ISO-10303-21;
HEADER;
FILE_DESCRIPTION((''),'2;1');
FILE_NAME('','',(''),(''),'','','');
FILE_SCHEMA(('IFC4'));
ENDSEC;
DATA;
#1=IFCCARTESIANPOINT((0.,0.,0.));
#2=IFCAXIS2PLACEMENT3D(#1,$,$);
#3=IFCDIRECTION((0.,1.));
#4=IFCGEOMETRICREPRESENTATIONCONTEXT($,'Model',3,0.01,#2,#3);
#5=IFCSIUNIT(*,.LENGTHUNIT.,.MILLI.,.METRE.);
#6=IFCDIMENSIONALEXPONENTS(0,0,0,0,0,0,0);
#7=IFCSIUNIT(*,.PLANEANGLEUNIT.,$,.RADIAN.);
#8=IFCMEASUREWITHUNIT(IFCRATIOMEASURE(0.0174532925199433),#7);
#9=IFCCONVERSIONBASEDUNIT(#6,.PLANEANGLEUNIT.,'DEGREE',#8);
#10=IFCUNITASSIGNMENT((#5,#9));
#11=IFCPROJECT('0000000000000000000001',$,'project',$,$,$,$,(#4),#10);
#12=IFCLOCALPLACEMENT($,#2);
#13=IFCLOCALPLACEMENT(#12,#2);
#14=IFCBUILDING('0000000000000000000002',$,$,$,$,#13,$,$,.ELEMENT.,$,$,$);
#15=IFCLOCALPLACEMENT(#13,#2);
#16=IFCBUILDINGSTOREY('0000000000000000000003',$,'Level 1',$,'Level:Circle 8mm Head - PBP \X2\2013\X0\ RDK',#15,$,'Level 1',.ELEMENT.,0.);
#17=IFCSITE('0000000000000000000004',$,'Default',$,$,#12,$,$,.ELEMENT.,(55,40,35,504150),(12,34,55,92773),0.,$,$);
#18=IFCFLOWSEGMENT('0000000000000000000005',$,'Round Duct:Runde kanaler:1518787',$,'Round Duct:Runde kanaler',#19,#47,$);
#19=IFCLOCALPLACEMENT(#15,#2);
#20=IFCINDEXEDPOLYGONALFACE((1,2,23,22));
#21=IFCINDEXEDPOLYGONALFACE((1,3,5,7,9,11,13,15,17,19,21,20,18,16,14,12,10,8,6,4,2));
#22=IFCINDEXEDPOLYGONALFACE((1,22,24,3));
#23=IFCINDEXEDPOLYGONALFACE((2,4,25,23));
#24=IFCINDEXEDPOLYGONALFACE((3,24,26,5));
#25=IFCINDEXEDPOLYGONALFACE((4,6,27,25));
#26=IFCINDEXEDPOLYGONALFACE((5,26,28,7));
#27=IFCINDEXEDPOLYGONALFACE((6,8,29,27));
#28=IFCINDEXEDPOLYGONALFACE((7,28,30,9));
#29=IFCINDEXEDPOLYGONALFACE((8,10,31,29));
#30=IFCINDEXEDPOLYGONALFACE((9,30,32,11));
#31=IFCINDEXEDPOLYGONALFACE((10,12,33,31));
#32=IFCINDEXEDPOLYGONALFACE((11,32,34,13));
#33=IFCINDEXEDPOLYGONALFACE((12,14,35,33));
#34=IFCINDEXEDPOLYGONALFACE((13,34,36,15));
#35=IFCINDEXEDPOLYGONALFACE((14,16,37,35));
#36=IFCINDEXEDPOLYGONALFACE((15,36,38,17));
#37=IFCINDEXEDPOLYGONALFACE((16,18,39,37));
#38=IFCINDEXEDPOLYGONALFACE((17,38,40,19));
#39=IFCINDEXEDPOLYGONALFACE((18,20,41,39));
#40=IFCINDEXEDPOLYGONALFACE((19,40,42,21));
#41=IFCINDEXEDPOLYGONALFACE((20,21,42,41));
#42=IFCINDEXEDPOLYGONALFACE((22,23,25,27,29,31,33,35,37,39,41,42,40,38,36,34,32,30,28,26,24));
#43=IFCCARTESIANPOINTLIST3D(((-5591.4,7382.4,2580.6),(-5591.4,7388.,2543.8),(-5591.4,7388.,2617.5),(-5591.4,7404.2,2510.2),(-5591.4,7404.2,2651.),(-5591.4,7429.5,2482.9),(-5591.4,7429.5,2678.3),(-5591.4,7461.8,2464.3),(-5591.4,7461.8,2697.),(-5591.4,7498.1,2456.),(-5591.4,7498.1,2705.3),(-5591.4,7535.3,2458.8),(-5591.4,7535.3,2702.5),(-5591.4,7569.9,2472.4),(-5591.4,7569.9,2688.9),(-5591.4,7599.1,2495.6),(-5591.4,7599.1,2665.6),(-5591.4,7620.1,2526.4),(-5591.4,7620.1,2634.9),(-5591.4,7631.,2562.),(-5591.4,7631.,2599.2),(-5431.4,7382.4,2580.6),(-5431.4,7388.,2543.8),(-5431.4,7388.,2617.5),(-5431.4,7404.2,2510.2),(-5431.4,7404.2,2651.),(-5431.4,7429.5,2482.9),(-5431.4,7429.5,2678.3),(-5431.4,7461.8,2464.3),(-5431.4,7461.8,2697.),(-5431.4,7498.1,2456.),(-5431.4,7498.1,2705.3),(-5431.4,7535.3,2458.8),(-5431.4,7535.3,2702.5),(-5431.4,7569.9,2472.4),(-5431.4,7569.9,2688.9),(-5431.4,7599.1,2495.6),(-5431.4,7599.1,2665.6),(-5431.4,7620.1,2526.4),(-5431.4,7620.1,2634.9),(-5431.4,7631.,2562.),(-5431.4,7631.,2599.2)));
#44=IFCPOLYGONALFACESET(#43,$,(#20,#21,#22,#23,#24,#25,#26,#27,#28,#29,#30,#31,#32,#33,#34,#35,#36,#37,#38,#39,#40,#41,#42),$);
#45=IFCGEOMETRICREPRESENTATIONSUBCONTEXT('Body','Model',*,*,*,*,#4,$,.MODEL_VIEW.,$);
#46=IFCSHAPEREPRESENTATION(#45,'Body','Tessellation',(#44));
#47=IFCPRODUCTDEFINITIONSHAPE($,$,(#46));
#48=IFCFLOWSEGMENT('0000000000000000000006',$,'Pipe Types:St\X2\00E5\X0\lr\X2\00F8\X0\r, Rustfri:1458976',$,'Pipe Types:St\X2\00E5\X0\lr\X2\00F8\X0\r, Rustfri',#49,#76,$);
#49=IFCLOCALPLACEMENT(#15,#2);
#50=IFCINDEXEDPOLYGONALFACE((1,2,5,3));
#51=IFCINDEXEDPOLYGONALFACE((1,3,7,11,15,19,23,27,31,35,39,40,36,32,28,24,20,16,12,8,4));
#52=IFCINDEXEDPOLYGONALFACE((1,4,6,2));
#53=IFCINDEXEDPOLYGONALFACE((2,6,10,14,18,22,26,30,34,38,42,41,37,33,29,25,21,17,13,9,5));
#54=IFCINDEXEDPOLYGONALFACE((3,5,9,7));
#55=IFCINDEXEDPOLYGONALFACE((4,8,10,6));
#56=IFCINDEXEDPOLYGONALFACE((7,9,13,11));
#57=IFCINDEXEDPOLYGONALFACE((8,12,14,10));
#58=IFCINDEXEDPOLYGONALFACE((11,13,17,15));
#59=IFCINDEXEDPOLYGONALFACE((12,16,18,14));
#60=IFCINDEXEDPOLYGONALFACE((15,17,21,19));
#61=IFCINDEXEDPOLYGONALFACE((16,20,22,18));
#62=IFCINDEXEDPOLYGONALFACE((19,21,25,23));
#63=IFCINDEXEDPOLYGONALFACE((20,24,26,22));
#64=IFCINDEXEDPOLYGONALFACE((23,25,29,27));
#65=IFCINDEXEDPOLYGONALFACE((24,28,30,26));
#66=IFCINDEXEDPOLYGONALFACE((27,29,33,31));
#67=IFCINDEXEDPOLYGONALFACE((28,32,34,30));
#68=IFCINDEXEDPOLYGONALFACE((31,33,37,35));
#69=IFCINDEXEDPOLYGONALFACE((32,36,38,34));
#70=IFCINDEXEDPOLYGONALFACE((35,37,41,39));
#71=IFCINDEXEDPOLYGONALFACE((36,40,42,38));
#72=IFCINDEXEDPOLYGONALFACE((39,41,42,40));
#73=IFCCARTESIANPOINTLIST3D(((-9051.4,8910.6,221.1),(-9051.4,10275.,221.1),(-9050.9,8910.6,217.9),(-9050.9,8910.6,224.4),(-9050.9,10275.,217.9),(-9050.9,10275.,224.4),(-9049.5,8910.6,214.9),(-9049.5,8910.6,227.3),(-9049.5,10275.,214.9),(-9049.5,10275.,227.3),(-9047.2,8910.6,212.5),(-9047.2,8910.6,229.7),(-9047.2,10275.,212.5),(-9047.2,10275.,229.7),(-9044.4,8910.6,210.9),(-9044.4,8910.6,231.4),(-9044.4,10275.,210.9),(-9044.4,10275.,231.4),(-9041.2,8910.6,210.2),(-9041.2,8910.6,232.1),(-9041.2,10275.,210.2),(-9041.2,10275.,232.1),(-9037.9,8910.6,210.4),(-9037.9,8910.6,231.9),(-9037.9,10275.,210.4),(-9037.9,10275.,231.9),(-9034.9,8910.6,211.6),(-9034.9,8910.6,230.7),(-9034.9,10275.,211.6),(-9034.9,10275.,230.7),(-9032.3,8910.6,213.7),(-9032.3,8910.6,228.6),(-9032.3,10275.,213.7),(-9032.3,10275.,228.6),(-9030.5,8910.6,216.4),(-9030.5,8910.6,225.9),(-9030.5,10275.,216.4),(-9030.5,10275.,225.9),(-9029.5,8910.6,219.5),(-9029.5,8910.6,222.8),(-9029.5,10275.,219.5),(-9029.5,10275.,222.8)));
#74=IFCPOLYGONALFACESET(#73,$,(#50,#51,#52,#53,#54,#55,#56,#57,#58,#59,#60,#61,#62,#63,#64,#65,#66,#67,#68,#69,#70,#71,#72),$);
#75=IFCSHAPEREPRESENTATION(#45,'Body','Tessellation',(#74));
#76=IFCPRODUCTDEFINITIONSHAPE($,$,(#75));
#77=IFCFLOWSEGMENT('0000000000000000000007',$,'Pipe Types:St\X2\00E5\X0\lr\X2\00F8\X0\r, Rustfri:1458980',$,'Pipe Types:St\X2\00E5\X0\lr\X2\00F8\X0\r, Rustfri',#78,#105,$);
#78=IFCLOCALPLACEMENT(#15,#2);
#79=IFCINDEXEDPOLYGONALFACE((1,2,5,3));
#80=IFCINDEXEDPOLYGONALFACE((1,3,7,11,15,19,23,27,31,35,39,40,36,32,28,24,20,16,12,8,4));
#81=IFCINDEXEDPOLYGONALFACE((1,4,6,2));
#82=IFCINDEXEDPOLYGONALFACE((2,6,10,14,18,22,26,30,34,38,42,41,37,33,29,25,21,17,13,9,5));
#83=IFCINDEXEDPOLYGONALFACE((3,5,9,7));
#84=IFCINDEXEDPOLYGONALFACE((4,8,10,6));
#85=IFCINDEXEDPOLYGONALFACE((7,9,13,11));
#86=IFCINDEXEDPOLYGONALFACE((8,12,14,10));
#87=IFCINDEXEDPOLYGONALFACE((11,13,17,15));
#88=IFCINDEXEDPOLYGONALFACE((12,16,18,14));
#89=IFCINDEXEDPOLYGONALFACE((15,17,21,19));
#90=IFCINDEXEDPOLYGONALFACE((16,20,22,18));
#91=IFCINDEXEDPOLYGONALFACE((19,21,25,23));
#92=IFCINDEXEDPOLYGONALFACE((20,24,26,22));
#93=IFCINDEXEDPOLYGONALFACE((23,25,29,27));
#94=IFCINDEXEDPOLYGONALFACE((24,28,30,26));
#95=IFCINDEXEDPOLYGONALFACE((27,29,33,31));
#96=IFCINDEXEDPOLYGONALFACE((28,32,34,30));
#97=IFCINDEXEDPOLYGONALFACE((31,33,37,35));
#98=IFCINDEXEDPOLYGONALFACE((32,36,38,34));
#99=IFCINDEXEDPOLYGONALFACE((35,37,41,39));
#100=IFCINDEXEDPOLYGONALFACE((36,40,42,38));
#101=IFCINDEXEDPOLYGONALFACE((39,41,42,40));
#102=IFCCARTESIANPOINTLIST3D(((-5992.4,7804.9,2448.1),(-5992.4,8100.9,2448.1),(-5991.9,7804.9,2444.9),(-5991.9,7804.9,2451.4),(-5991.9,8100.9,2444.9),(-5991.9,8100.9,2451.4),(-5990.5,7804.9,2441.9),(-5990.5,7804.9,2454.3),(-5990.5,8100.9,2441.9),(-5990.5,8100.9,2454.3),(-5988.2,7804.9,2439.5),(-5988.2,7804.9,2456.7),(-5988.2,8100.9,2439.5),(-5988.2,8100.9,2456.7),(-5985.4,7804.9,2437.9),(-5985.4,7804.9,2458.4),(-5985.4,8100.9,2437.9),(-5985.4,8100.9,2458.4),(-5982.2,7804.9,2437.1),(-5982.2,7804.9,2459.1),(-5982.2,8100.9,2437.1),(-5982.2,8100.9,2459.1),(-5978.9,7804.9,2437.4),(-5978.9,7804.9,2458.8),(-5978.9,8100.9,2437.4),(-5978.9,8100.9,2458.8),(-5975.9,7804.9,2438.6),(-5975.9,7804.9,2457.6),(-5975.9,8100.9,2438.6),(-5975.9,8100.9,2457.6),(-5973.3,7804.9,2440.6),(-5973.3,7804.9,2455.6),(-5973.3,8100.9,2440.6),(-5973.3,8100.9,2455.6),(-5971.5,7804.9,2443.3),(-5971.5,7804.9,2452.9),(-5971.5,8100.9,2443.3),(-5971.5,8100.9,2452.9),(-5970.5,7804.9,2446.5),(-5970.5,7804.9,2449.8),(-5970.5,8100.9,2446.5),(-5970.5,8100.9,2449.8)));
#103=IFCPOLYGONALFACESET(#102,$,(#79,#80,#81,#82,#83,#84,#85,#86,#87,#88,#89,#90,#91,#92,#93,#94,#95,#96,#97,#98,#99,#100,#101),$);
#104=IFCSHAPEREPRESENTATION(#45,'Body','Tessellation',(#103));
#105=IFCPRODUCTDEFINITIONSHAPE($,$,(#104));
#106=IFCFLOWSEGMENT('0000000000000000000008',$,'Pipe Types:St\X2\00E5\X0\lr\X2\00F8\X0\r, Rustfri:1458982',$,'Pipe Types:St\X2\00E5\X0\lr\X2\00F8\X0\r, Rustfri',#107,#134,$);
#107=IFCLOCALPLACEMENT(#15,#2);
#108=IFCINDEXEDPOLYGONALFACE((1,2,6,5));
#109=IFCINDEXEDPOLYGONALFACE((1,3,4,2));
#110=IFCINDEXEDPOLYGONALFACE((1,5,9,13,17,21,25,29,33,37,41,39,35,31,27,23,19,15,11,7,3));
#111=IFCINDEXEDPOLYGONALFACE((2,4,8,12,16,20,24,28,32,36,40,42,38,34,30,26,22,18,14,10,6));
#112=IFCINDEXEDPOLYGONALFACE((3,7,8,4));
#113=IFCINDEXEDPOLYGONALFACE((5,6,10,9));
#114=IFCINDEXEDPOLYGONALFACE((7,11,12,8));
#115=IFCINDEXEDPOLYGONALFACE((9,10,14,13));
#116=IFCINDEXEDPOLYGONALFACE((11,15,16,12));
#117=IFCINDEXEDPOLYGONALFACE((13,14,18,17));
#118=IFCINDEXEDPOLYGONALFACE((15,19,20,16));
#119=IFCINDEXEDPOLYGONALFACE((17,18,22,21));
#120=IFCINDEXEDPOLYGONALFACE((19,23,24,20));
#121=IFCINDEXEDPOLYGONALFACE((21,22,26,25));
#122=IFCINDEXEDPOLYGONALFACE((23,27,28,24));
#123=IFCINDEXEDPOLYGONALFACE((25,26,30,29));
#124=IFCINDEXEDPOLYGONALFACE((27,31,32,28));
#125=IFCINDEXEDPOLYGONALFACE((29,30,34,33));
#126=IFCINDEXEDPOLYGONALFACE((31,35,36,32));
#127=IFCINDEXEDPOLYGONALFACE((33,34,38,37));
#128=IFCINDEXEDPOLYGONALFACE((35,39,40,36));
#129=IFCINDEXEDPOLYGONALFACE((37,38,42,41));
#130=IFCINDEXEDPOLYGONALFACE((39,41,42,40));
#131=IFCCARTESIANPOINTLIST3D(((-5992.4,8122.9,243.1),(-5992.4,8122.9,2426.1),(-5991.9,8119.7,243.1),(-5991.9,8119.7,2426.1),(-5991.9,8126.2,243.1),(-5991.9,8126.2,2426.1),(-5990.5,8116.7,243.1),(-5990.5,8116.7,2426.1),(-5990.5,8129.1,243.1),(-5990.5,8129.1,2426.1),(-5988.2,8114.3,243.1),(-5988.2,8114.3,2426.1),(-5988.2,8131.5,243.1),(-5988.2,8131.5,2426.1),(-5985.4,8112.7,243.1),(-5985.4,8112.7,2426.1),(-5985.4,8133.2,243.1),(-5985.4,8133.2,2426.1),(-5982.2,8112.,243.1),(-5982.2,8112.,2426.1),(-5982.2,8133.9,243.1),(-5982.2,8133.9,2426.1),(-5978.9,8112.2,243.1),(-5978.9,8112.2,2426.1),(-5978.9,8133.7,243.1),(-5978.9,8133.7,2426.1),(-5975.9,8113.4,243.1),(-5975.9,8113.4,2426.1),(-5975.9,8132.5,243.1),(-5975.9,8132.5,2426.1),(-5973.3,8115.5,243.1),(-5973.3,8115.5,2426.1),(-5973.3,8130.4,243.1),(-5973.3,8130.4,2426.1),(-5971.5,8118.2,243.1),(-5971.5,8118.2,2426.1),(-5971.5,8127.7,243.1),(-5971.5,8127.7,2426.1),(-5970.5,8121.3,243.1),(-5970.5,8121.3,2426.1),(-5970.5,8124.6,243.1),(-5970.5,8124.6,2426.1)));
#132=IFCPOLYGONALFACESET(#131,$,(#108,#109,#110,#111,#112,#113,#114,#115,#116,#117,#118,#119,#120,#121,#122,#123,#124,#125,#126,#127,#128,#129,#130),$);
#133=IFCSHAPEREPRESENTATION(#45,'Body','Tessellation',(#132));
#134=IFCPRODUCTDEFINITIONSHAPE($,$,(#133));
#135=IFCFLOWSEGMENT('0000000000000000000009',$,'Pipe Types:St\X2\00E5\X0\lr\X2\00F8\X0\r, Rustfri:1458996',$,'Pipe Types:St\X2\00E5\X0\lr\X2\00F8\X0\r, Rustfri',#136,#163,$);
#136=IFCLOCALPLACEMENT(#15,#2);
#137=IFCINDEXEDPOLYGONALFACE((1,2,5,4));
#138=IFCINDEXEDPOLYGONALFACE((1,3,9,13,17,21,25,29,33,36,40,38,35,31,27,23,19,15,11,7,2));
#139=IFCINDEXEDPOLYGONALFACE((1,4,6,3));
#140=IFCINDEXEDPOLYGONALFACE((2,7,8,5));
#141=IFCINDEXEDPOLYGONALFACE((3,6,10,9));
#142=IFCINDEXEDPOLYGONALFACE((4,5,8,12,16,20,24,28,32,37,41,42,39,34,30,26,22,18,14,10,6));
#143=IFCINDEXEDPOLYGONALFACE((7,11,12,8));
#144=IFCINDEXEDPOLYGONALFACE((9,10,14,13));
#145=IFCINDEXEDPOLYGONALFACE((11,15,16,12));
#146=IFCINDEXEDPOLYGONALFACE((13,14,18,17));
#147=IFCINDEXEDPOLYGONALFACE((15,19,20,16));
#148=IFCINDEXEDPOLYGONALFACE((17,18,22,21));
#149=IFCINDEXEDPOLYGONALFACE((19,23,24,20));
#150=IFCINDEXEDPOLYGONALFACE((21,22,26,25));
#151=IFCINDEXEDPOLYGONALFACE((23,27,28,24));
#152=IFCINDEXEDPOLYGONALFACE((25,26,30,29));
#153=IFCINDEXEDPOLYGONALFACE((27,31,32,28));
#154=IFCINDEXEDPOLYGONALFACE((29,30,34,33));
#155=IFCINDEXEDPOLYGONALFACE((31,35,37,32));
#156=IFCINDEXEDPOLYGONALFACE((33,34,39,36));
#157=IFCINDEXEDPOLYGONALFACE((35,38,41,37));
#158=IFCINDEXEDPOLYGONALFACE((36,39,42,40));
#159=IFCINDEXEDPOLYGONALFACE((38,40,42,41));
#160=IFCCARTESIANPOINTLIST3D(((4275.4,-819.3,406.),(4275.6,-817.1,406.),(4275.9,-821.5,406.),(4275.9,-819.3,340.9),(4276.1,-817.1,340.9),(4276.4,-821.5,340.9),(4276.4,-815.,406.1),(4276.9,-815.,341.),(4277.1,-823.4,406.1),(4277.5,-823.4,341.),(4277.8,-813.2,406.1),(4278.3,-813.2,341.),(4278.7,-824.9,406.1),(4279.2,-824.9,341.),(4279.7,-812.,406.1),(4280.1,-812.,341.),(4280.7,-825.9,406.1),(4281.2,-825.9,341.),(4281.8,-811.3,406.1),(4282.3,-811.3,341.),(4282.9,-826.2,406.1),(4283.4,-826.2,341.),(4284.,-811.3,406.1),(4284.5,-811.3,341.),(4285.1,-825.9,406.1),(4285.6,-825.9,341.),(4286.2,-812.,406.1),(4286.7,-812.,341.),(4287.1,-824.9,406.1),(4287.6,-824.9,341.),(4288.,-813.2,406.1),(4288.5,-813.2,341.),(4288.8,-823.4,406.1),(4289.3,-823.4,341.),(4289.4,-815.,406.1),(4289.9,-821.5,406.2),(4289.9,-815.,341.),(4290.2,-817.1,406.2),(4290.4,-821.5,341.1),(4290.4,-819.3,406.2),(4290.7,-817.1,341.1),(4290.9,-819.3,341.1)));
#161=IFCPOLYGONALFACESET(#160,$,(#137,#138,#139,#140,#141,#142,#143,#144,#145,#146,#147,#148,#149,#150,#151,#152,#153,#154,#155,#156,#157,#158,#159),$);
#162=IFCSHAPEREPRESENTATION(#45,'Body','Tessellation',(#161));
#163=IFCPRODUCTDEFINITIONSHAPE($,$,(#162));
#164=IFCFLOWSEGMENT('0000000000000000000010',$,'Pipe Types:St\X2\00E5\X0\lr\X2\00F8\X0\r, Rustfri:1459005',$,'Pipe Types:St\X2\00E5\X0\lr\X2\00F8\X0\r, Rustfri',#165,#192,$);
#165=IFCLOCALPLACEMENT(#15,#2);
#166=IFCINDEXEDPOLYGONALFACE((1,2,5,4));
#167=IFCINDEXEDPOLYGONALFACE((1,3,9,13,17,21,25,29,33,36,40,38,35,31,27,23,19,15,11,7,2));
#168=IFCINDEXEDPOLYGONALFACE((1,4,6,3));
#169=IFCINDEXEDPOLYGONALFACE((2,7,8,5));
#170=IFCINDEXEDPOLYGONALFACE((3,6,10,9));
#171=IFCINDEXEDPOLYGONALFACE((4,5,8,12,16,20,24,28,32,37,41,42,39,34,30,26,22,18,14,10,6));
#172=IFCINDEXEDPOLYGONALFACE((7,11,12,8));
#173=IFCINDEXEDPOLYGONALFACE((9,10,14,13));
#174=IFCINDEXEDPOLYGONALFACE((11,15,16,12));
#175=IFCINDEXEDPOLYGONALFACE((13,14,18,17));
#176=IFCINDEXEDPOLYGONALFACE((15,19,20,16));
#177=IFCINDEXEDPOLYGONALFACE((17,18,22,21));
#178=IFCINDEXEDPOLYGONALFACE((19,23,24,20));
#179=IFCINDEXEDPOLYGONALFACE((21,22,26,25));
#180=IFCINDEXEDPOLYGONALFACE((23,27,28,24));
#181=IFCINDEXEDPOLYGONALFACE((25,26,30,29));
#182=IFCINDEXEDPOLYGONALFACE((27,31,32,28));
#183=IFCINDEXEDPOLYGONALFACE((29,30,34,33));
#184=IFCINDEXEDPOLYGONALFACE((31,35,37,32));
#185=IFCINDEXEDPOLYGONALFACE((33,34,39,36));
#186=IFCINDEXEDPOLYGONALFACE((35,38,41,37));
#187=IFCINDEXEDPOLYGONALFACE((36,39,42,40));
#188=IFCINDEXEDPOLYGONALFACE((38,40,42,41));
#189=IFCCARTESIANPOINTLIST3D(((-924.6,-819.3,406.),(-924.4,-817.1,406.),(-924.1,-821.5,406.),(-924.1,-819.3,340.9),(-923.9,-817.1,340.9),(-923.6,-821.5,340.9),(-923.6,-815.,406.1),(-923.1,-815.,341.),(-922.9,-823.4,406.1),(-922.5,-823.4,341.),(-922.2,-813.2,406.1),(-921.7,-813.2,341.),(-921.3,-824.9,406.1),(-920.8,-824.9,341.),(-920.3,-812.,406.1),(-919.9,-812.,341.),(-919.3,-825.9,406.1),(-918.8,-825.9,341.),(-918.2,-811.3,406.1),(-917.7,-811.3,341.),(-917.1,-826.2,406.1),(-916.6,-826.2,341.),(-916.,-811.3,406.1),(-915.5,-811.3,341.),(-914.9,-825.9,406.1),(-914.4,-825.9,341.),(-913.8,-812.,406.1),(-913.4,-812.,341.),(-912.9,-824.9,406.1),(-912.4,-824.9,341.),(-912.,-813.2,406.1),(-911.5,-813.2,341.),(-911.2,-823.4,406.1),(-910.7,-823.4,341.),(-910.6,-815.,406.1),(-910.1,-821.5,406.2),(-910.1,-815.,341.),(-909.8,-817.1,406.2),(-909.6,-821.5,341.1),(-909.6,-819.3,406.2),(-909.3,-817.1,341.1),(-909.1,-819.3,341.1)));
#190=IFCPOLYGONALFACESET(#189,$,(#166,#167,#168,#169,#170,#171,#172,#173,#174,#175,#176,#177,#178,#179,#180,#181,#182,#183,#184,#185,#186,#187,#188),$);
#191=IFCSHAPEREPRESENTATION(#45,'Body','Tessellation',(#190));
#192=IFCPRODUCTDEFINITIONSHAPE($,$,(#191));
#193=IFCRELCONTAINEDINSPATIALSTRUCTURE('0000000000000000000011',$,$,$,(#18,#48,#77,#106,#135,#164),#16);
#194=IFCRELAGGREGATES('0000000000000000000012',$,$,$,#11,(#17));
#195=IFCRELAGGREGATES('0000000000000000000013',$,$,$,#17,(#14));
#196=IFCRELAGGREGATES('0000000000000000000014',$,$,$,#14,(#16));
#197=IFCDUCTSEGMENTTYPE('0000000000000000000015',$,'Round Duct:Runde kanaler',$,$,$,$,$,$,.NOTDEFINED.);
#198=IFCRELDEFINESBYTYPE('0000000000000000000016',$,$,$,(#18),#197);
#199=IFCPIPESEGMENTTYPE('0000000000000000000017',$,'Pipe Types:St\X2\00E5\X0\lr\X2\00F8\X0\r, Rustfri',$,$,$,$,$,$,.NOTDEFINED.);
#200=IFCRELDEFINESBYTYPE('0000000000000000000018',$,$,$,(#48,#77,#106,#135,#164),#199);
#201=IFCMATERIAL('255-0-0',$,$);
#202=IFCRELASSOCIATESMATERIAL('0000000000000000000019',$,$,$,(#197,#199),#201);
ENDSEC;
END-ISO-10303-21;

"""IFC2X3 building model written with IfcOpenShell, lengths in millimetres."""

from ifc_helpers import new_model, entity, si_unit, converted_unit, direction, frame, frame_2d, origin, origin_2d_with_axis, place, context, subcontext, project, spatial, circle, extrude, material, type_object, element, save


model = new_model("IFC2X3")

# Units and contexts
model_context = context("Model", 3, precision=0.01, world=origin(), true_north=direction((0.0, 1.0)))
body_context = subcontext(model_context, "Body", "Model", "MODEL_VIEW")
ifc_project = project(units=[si_unit("LENGTHUNIT", "METRE", prefix="MILLI"), converted_unit("PLANEANGLEUNIT", "DEGREE", entity("IfcRatioMeasure", 0.0174532925199433), si_unit("PLANEANGLEUNIT", "RADIAN"), dimensions=[0, 0, 0, 0, 0, 0, 0])], contexts=[model_context])

# Site, building, storey
site_placement = place(None, origin())
site = spatial("IfcSite", under=ifc_project, at=site_placement, Name="Default", CompositionType="ELEMENT", RefLatitude=(55, 40, 35, 504150), RefLongitude=(12, 34, 55, 92773), RefElevation=0.0)
building_placement = place(site_placement, origin())
building = spatial("IfcBuilding", under=site, at=building_placement, CompositionType="ELEMENT")
storey_placement = place(building_placement, origin())
storey = spatial("IfcBuildingStorey", under=building, at=storey_placement, Name="Level 1", ObjectType="Level:Circle 8mm Head - PBP – RDK", LongName="Level 1", CompositionType="ELEMENT", Elevation=0.0)

# Flow segments
ifc_material = material(Name="255-0-0")
duct_segment_type = type_object("IfcDuctSegmentType", Name="Round Duct:Runde kanaler", PredefinedType="NOTDEFINED", material=ifc_material)
flow_segment_1_placement = place(storey_placement, origin())
element("IfcFlowSegment", 1, at=flow_segment_1_placement, inside=storey, type_object=duct_segment_type, Name="Round Duct:Runde kanaler:1518787", ObjectType="Round Duct:Runde kanaler", context=body_context, shape_type="SweptSolid", body=[
    extrude(circle(Radius=125.0, at=frame_2d((0.0, 0.0), x_axis=(1.0, 0.0))), frame((-5591.4, 7507.4, 2580.6), z_axis=(1.0, 0.0, 0.0), x_axis=(0.0, -1.0, 0.0)), (0.0, 0.0, 1.0), 160.0),
])
pipe_segment_type = type_object("IfcPipeSegmentType", Name="Pipe Types:Stålrør, Rustfri", PredefinedType="NOTDEFINED", material=ifc_material)
flow_segment_2_placement = place(storey_placement, origin())
element("IfcFlowSegment", 2, at=flow_segment_2_placement, inside=storey, type_object=pipe_segment_type, Name="Pipe Types:Stålrør, Rustfri:1458976", ObjectType="Pipe Types:Stålrør, Rustfri", context=body_context, shape_type="SweptSolid", body=[
    extrude(circle(Radius=11.0, at=origin_2d_with_axis()), frame((-9040.4, 8910.6, 221.1), z_axis=(0.0, 1.0, 0.0), x_axis=(-1.0, 0.0, 0.0)), (0.0, 0.0, 1.0), 1364.5),
])
flow_segment_3_placement = place(storey_placement, origin())
element("IfcFlowSegment", 3, at=flow_segment_3_placement, inside=storey, type_object=pipe_segment_type, Name="Pipe Types:Stålrør, Rustfri:1458980", ObjectType="Pipe Types:Stålrør, Rustfri", context=body_context, shape_type="SweptSolid", body=[
    extrude(circle(Radius=11.0, at=origin_2d_with_axis()), frame((-5981.4, 7804.9, 2448.1), z_axis=(0.0, 1.0, 0.0), x_axis=(-1.0, 0.0, 0.0)), (0.0, 0.0, 1.0), 296.0),
])
flow_segment_4_placement = place(storey_placement, origin())
element("IfcFlowSegment", 4, at=flow_segment_4_placement, inside=storey, type_object=pipe_segment_type, Name="Pipe Types:Stålrør, Rustfri:1458982", ObjectType="Pipe Types:Stålrør, Rustfri", context=body_context, shape_type="SweptSolid", body=[
    extrude(circle(Radius=11.0, at=origin_2d_with_axis()), frame((-5981.4, 8122.9, 243.1), z_axis=(0.0, 0.0, 1.0), x_axis=(-1.0, 0.0, 0.0)), (0.0, 0.0, 1.0), 2183.0),
])
flow_segment_5_placement = place(storey_placement, origin())
element("IfcFlowSegment", 5, at=flow_segment_5_placement, inside=storey, type_object=pipe_segment_type, Name="Pipe Types:Stålrør, Rustfri:1458996", ObjectType="Pipe Types:Stålrør, Rustfri", context=body_context, shape_type="SweptSolid", body=[
    extrude(circle(Radius=7.5, at=origin_2d_with_axis()), frame((4283.4, -818.7, 341.0), z_axis=(-0.007412, 0.0, 0.999973), x_axis=(0.0, -1.0, 0.0)), (0.0, 0.0, 1.0), 65.1),
])
flow_segment_6_placement = place(storey_placement, origin())
element("IfcFlowSegment", 6, at=flow_segment_6_placement, inside=storey, type_object=pipe_segment_type, Name="Pipe Types:Stålrør, Rustfri:1459005", ObjectType="Pipe Types:Stålrør, Rustfri", context=body_context, shape_type="SweptSolid", body=[
    extrude(circle(Radius=7.5, at=origin_2d_with_axis()), frame((-917.1, -818.7, 406.1), z_axis=(0.007363, 0.0, -0.999973), x_axis=(0.0, -1.0, 0.0)), (0.0, 0.0, 1.0), 65.1),
])

save(model, "model.ifc")
